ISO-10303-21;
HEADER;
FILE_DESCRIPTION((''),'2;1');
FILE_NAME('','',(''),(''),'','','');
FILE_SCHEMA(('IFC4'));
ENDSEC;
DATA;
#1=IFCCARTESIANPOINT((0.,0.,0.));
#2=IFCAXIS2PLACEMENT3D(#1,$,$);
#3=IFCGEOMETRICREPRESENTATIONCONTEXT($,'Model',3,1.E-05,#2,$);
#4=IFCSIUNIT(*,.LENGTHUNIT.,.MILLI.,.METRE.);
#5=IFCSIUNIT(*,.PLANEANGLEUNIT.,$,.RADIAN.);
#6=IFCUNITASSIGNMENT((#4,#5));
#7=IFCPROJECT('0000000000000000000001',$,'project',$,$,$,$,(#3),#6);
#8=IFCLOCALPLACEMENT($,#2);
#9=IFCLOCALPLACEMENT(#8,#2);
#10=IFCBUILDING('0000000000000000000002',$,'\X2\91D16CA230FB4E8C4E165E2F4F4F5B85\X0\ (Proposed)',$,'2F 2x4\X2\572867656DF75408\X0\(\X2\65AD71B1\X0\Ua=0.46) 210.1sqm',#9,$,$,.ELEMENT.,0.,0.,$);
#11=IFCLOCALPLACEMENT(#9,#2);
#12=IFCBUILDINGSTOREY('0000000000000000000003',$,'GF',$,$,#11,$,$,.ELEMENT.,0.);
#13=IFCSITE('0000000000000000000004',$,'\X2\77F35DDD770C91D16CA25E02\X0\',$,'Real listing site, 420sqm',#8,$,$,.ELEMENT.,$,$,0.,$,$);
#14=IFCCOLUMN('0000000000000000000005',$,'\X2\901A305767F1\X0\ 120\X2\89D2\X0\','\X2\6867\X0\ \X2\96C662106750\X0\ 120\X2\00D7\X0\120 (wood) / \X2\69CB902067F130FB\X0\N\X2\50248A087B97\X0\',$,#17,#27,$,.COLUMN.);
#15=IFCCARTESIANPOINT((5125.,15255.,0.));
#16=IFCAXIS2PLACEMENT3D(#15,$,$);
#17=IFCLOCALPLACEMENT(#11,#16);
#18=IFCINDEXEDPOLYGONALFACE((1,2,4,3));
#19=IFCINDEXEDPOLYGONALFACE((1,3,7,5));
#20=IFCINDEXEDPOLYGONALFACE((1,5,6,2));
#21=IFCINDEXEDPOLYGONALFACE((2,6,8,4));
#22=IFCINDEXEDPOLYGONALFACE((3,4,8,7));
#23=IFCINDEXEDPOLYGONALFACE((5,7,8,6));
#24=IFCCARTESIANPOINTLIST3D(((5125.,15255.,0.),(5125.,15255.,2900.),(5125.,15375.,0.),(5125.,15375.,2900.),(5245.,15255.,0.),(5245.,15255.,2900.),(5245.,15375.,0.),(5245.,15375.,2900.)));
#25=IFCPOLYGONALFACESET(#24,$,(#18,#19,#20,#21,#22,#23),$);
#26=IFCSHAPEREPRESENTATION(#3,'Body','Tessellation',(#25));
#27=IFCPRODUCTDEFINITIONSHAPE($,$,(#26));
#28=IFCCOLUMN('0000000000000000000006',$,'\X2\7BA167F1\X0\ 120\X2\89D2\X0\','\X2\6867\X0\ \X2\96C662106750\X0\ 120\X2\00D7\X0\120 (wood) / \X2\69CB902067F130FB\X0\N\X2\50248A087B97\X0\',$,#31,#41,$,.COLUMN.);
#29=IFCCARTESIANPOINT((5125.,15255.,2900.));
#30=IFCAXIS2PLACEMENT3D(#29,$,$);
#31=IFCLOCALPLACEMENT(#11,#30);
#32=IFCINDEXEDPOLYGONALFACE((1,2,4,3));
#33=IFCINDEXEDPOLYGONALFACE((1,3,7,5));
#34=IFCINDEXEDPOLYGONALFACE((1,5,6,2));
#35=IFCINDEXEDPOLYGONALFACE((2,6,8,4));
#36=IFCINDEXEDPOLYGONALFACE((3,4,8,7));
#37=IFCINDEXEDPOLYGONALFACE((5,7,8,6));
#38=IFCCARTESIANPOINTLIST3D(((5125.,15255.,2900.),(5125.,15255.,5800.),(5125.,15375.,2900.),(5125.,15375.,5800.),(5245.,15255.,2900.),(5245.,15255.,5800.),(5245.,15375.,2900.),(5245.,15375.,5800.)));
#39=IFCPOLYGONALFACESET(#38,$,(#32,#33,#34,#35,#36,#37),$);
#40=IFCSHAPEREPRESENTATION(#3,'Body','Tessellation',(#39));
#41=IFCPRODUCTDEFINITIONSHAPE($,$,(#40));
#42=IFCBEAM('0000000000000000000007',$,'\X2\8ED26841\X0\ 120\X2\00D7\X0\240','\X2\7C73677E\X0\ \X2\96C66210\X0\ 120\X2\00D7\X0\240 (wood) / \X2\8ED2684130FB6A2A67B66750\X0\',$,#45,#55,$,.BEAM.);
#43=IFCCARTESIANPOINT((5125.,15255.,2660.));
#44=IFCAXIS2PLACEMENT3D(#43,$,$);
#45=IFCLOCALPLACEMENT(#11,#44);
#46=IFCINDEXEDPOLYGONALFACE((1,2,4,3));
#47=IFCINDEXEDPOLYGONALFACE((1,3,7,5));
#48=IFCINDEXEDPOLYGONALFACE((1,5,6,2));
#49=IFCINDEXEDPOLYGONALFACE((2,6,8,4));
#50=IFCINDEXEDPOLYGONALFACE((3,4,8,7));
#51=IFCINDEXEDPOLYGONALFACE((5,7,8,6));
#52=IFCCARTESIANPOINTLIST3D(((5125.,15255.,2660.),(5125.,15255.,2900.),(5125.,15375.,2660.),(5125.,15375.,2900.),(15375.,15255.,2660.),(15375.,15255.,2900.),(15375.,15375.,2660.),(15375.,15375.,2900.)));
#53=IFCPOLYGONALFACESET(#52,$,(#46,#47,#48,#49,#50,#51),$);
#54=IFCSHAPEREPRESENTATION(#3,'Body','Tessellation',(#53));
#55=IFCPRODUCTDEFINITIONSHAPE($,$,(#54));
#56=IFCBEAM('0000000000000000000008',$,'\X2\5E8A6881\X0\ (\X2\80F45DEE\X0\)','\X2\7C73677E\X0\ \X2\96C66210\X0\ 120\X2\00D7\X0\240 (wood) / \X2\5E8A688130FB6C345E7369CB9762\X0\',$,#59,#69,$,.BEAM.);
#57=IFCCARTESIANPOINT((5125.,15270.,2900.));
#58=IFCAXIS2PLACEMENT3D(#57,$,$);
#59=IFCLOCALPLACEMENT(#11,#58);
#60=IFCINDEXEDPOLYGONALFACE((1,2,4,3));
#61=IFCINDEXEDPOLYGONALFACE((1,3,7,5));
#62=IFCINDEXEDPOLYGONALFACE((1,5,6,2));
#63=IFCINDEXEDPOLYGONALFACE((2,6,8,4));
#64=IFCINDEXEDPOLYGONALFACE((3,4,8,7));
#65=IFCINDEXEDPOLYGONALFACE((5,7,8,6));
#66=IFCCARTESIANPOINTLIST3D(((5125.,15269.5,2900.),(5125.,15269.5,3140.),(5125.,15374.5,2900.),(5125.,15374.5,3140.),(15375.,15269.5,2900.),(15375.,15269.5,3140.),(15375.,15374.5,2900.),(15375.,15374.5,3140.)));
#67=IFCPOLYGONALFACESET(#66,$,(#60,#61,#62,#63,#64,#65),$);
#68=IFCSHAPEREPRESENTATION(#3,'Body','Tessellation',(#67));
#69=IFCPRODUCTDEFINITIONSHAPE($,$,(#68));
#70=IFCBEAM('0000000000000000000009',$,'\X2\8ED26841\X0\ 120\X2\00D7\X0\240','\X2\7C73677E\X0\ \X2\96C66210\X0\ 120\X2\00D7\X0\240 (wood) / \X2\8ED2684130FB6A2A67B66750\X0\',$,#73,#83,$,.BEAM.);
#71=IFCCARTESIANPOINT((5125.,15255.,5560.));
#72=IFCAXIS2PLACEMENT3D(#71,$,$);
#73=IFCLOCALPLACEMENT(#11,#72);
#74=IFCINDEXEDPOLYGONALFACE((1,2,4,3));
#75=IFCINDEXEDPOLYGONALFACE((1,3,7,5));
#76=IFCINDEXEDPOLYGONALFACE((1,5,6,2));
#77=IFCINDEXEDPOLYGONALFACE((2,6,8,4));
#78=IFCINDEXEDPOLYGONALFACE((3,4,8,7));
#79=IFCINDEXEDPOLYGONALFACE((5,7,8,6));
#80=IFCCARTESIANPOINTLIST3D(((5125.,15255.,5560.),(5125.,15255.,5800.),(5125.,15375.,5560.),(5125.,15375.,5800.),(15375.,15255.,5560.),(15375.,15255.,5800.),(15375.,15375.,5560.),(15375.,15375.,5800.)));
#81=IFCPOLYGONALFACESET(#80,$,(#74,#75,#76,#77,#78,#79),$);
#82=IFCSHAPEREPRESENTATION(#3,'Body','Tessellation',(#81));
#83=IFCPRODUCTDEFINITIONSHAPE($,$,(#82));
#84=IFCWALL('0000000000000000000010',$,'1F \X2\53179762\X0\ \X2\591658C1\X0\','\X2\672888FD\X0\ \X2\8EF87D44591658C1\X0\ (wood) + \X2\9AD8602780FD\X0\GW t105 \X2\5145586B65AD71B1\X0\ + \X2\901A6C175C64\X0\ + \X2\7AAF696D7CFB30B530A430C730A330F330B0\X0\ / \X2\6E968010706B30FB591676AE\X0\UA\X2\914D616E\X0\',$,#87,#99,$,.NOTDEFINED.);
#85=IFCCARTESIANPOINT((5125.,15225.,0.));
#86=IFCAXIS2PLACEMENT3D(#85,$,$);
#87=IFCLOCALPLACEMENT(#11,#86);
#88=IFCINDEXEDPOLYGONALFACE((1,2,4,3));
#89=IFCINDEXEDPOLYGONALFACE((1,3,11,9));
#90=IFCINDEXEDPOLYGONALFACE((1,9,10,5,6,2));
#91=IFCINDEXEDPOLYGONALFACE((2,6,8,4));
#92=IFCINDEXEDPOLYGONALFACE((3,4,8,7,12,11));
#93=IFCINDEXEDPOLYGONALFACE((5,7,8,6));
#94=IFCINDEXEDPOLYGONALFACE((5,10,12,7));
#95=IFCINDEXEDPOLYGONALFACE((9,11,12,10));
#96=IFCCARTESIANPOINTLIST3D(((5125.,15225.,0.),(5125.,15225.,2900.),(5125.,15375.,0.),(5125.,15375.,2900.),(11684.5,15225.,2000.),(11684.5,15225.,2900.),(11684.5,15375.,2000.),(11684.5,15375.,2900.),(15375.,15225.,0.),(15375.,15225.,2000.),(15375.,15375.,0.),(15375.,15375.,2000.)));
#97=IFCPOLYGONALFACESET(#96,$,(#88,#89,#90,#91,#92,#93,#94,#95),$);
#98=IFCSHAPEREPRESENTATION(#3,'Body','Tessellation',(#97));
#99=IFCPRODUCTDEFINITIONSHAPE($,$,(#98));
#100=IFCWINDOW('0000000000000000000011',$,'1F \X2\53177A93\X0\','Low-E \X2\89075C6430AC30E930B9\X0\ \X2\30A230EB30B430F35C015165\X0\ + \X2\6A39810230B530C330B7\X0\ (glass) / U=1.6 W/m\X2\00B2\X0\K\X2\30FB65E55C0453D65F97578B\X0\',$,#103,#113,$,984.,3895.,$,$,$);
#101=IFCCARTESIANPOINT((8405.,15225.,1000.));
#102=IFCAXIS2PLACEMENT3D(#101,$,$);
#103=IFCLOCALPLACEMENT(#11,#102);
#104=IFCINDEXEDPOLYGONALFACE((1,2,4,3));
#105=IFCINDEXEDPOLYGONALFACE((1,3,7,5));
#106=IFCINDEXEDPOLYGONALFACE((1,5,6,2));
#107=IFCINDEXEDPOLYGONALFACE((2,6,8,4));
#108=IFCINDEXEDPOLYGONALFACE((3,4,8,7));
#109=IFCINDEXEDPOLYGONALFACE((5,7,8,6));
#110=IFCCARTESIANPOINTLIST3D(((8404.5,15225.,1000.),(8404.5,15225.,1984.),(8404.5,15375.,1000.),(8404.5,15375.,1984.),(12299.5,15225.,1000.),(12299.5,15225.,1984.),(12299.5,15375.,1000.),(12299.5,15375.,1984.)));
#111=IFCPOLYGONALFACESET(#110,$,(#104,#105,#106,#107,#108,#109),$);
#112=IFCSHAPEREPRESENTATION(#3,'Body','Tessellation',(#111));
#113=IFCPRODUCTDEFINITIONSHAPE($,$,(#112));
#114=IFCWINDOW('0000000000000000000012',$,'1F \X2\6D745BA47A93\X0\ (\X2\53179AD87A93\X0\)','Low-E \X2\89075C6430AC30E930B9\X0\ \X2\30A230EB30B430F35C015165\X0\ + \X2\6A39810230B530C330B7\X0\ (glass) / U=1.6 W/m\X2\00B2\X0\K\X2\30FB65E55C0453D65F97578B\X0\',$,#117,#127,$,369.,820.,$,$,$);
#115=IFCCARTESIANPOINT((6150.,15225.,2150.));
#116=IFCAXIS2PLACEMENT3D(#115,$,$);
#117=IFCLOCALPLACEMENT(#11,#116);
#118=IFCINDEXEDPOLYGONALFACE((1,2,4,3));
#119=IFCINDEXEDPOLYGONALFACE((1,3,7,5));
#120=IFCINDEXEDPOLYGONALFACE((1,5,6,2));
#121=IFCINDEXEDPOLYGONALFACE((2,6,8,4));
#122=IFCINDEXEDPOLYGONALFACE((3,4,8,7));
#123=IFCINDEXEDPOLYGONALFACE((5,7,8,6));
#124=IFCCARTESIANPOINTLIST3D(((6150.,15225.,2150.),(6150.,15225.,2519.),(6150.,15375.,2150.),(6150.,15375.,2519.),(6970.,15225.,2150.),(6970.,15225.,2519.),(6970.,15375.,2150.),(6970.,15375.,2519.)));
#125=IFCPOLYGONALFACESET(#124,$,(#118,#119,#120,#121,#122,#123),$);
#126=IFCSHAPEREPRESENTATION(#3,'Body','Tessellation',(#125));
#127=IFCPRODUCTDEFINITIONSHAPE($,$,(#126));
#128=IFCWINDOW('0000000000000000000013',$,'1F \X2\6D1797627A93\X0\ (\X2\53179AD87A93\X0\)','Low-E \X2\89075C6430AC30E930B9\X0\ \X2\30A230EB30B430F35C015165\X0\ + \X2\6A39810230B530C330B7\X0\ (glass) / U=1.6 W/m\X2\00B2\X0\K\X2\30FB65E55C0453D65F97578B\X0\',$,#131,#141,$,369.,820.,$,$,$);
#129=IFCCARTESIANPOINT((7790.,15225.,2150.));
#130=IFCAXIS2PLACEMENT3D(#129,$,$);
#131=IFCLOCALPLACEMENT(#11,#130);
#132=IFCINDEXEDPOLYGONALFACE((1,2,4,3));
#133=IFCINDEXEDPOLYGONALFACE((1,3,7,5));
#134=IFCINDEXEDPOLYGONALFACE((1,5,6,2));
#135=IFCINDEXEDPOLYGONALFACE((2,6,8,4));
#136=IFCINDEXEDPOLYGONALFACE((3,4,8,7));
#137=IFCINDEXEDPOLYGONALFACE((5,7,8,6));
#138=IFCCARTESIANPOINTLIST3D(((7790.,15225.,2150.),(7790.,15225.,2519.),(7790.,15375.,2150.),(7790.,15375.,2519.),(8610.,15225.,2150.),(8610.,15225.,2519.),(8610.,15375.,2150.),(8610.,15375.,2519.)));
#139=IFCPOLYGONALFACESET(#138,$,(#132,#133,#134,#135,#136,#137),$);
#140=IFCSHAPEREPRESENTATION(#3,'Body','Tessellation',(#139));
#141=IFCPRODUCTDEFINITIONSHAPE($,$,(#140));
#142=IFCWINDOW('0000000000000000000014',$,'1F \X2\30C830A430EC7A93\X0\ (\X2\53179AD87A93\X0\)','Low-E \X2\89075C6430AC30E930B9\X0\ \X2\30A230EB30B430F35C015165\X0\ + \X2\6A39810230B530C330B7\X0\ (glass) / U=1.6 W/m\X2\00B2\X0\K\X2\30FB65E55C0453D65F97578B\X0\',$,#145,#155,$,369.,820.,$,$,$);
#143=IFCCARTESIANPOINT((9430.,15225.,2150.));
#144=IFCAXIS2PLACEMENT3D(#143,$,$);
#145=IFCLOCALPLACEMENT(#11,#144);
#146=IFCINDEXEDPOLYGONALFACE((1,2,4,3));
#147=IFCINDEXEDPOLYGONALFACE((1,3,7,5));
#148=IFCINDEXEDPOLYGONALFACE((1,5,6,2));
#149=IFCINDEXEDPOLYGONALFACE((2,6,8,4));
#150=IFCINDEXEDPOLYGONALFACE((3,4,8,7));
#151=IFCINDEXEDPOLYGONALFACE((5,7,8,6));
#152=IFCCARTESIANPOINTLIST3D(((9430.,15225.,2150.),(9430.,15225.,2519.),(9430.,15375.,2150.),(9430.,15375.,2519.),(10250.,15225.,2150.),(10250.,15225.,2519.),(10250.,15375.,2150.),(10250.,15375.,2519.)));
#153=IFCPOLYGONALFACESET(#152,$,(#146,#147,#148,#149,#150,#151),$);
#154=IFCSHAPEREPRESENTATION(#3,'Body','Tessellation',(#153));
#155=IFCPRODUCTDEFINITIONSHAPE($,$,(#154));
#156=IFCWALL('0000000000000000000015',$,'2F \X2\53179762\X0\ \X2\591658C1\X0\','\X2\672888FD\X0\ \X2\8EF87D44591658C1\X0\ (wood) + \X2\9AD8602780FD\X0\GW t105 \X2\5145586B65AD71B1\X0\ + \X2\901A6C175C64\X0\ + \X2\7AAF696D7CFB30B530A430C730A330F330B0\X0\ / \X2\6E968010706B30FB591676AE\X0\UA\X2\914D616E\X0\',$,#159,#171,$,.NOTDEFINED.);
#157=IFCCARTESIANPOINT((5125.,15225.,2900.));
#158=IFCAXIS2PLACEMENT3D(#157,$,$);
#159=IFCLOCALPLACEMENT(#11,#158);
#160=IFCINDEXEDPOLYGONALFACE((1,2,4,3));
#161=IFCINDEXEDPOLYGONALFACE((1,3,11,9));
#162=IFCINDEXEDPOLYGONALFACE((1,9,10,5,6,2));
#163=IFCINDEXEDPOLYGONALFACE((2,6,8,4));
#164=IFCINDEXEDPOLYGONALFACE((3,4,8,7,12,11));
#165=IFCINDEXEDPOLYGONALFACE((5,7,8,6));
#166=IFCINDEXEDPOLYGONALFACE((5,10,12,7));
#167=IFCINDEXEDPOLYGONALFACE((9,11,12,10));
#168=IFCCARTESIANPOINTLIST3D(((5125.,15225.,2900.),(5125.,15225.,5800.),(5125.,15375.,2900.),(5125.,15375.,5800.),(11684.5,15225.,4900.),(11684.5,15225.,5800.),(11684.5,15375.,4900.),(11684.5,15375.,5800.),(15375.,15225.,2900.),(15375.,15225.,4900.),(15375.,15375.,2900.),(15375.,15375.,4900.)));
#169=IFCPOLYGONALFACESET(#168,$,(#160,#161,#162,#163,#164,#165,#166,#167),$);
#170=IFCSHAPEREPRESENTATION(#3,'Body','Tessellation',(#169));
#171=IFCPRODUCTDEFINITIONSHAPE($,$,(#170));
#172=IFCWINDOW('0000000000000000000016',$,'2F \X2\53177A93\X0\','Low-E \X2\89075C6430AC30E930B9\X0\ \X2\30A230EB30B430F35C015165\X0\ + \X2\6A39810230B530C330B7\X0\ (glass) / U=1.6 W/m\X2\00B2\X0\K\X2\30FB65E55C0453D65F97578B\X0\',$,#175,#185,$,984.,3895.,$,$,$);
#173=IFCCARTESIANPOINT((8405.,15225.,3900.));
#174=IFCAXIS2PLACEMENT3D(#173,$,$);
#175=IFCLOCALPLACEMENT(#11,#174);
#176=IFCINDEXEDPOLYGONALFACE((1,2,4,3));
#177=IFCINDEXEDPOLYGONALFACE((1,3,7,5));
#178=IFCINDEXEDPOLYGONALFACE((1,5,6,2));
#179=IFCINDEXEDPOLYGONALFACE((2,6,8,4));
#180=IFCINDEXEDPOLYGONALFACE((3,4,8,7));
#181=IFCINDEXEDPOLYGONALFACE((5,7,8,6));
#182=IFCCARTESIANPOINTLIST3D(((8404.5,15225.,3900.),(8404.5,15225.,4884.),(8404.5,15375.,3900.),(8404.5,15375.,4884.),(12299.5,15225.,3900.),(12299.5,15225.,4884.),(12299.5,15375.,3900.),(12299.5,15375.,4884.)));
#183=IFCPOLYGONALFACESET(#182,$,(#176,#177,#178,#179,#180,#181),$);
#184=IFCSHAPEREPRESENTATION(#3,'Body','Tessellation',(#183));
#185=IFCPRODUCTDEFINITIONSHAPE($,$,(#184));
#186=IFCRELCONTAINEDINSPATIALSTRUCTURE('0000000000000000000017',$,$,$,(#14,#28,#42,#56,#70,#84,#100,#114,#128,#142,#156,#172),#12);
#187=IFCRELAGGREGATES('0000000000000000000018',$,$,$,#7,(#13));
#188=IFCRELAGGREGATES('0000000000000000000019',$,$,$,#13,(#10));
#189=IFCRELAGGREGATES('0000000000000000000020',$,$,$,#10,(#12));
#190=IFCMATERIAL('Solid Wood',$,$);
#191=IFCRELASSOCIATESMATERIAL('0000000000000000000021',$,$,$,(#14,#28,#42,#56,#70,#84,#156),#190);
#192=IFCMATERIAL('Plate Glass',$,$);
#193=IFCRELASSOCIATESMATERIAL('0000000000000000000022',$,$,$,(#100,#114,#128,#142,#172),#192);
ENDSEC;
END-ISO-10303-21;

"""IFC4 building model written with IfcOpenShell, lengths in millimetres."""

from ifc_helpers import new_model, si_unit, frame, frame_2d, origin, place, context, project, spatial, rectangle, extrude, material, element, fill, save


model = new_model("IFC4")

# Units and contexts
model_context = context("Model", 3, precision=1e-05, world=origin())
ifc_project = project(units=[si_unit("LENGTHUNIT", "METRE", prefix="MILLI"), si_unit("PLANEANGLEUNIT", "RADIAN")], contexts=[model_context])

# Site, building, storey
site_placement = place(None, origin())
site = spatial("IfcSite", under=ifc_project, at=site_placement, Name="石川県金沢市", ObjectType="Real listing site, 420sqm", CompositionType="ELEMENT", RefElevation=0.0)
building_placement = place(site_placement, origin())
building = spatial("IfcBuilding", under=site, at=building_placement, Name="金沢・二世帯住宅 (Proposed)", ObjectType="2F 2x4在来混合(断熱Ua=0.46) 210.1sqm", CompositionType="ELEMENT", ElevationOfRefHeight=0.0, ElevationOfTerrain=0.0)
storey_placement = place(building_placement, origin())
storey = spatial("IfcBuildingStorey", under=building, at=storey_placement, Name="GF", CompositionType="ELEMENT", Elevation=0.0)

# Columns
ifc_material_1 = material(Name="Solid Wood")
column_1_placement = place(storey_placement, frame((5125.0, 15255.0, 0.0)))
element("IfcColumn", 1, at=column_1_placement, inside=storey, material=ifc_material_1, Name="通し柱 120角", Description="桧 集成材 120×120 (wood) / 構造柱・N値計算", PredefinedType="COLUMN", context=model_context, shape_type="SweptSolid", body=[
    extrude(rectangle(XDim=120.0, YDim=120.0, at=frame_2d((60.0, 60.0))), frame((5125.0, 15255.0, 0.0)), (0.0, 0.0, 1.0), 2900.0),
])
column_2_placement = place(storey_placement, frame((5125.0, 15255.0, 2900.0)))
element("IfcColumn", 2, at=column_2_placement, inside=storey, material=ifc_material_1, Name="管柱 120角", Description="桧 集成材 120×120 (wood) / 構造柱・N値計算", PredefinedType="COLUMN", context=model_context, shape_type="SweptSolid", body=[
    extrude(rectangle(XDim=120.0, YDim=120.0, at=frame_2d((60.0, 60.0))), frame((5125.0, 15255.0, 2900.0)), (0.0, 0.0, 1.0), 2900.0),
])

# Beams
beam_1_placement = place(storey_placement, frame((5125.0, 15255.0, 2660.0)))
element("IfcBeam", 3, at=beam_1_placement, inside=storey, material=ifc_material_1, Name="軒桁 120×240", Description="米松 集成 120×240 (wood) / 軒桁・横架材", PredefinedType="BEAM", context=model_context, shape_type="SweptSolid", body=[
    extrude(rectangle(XDim=10250.0, YDim=120.0, at=frame_2d((5125.0, 60.0))), frame((5125.0, 15255.0, 2660.0)), (0.0, 0.0, 1.0), 240.0),
])
beam_2_placement = place(storey_placement, frame((5125.0, 15270.0, 2900.0)))
element("IfcBeam", 4, at=beam_2_placement, inside=storey, material=ifc_material_1, Name="床梁 (胴差)", Description="米松 集成 120×240 (wood) / 床梁・水平構面", PredefinedType="BEAM", context=model_context, shape_type="SweptSolid", body=[
    extrude(rectangle(XDim=10250.0, YDim=105.0, at=frame_2d((5125.0, 52.0))), frame((5125.0, 15270.0, 2900.0)), (0.0, 0.0, 1.0), 240.0),
])
beam_3_placement = place(storey_placement, frame((5125.0, 15255.0, 5560.0)))
element("IfcBeam", 5, at=beam_3_placement, inside=storey, material=ifc_material_1, Name="軒桁 120×240", Description="米松 集成 120×240 (wood) / 軒桁・横架材", PredefinedType="BEAM", context=model_context, shape_type="SweptSolid", body=[
    extrude(rectangle(XDim=10250.0, YDim=120.0, at=frame_2d((5125.0, 60.0))), frame((5125.0, 15255.0, 5560.0)), (0.0, 0.0, 1.0), 240.0),
])

# Wall, openings, windows
wall_1_placement = place(storey_placement, frame((5125.0, 15225.0, 0.0)))
wall_1 = element("IfcWall", 6, at=wall_1_placement, inside=storey, material=ifc_material_1, Name="1F 北面 外壁", Description="木製 軸組外壁 (wood) + 高性能GW t105 充填断熱 + 通気層 + 窯業系サイディング / 準耐火・外皮UA配慮", PredefinedType="NOTDEFINED", context=model_context, shape_type="SweptSolid", body=[
    extrude(rectangle(XDim=10250.0, YDim=150.0, at=frame_2d((5125.0, 75.0))), frame((5125.0, 15225.0, 0.0)), (0.0, 0.0, 1.0), 2900.0),
])
opening_1_placement = place(storey_placement, frame((8405.0, 15225.0, 1000.0)))
opening_1 = element("IfcOpeningElement", 7, at=opening_1_placement, cuts=wall_1, PredefinedType="NOTDEFINED", context=model_context, shape_type="SweptSolid", body=[
    extrude(rectangle(XDim=3895.0, YDim=150.0, at=frame_2d((1947.0, 75.0))), frame((8405.0, 15225.0, 1000.0)), (0.0, 0.0, 1.0), 984.0),
])
opening_2_placement = place(storey_placement, frame((6150.0, 15225.0, 2150.0)))
opening_2 = element("IfcOpeningElement", 8, at=opening_2_placement, cuts=wall_1, PredefinedType="NOTDEFINED", context=model_context, shape_type="SweptSolid", body=[
    extrude(rectangle(XDim=820.0, YDim=150.0, at=frame_2d((410.0, 75.0))), frame((6150.0, 15225.0, 2150.0)), (0.0, 0.0, 1.0), 369.0),
])
opening_3_placement = place(storey_placement, frame((7790.0, 15225.0, 2150.0)))
opening_3 = element("IfcOpeningElement", 9, at=opening_3_placement, cuts=wall_1, PredefinedType="NOTDEFINED", context=model_context, shape_type="SweptSolid", body=[
    extrude(rectangle(XDim=820.0, YDim=150.0, at=frame_2d((410.0, 75.0))), frame((7790.0, 15225.0, 2150.0)), (0.0, 0.0, 1.0), 369.0),
])
opening_4_placement = place(storey_placement, frame((9430.0, 15225.0, 2150.0)))
opening_4 = element("IfcOpeningElement", 10, at=opening_4_placement, cuts=wall_1, PredefinedType="NOTDEFINED", context=model_context, shape_type="SweptSolid", body=[
    extrude(rectangle(XDim=820.0, YDim=150.0, at=frame_2d((410.0, 75.0))), frame((9430.0, 15225.0, 2150.0)), (0.0, 0.0, 1.0), 369.0),
])
ifc_material_2 = material(Name="Plate Glass")
window_1_placement = place(storey_placement, frame((8405.0, 15225.0, 1000.0)))
window_1 = element("IfcWindow", 11, at=window_1_placement, inside=storey, material=ifc_material_2, Name="1F 北窓", Description="Low-E 複層ガラス アルゴン封入 + 樹脂サッシ (glass) / U=1.6 W/m²K・日射取得型", OverallHeight=984.0, OverallWidth=3895.0, context=model_context, shape_type="SweptSolid", body=[
    extrude(rectangle(XDim=3895.0, YDim=150.0, at=frame_2d((1947.0, 75.0))), frame((8405.0, 15225.0, 1000.0)), (0.0, 0.0, 1.0), 984.0),
])
fill(opening_1, window_1)
window_2_placement = place(storey_placement, frame((6150.0, 15225.0, 2150.0)))
window_2 = element("IfcWindow", 12, at=window_2_placement, inside=storey, material=ifc_material_2, Name="1F 浴室窓 (北高窓)", Description="Low-E 複層ガラス アルゴン封入 + 樹脂サッシ (glass) / U=1.6 W/m²K・日射取得型", OverallHeight=369.0, OverallWidth=820.0, context=model_context, shape_type="SweptSolid", body=[
    extrude(rectangle(XDim=820.0, YDim=150.0, at=frame_2d((410.0, 75.0))), frame((6150.0, 15225.0, 2150.0)), (0.0, 0.0, 1.0), 369.0),
])
fill(opening_2, window_2)
window_3_placement = place(storey_placement, frame((7790.0, 15225.0, 2150.0)))
window_3 = element("IfcWindow", 13, at=window_3_placement, inside=storey, material=ifc_material_2, Name="1F 洗面窓 (北高窓)", Description="Low-E 複層ガラス アルゴン封入 + 樹脂サッシ (glass) / U=1.6 W/m²K・日射取得型", OverallHeight=369.0, OverallWidth=820.0, context=model_context, shape_type="SweptSolid", body=[
    extrude(rectangle(XDim=820.0, YDim=150.0, at=frame_2d((410.0, 75.0))), frame((7790.0, 15225.0, 2150.0)), (0.0, 0.0, 1.0), 369.0),
])
fill(opening_3, window_3)
window_4_placement = place(storey_placement, frame((9430.0, 15225.0, 2150.0)))
window_4 = element("IfcWindow", 14, at=window_4_placement, inside=storey, material=ifc_material_2, Name="1F トイレ窓 (北高窓)", Description="Low-E 複層ガラス アルゴン封入 + 樹脂サッシ (glass) / U=1.6 W/m²K・日射取得型", OverallHeight=369.0, OverallWidth=820.0, context=model_context, shape_type="SweptSolid", body=[
    extrude(rectangle(XDim=820.0, YDim=150.0, at=frame_2d((410.0, 75.0))), frame((9430.0, 15225.0, 2150.0)), (0.0, 0.0, 1.0), 369.0),
])
fill(opening_4, window_4)

# Wall, opening, window
wall_2_placement = place(storey_placement, frame((5125.0, 15225.0, 2900.0)))
wall_2 = element("IfcWall", 15, at=wall_2_placement, inside=storey, material=ifc_material_1, Name="2F 北面 外壁", Description="木製 軸組外壁 (wood) + 高性能GW t105 充填断熱 + 通気層 + 窯業系サイディング / 準耐火・外皮UA配慮", PredefinedType="NOTDEFINED", context=model_context, shape_type="SweptSolid", body=[
    extrude(rectangle(XDim=10250.0, YDim=150.0, at=frame_2d((5125.0, 75.0))), frame((5125.0, 15225.0, 2900.0)), (0.0, 0.0, 1.0), 2900.0),
])
opening_5_placement = place(storey_placement, frame((8405.0, 15225.0, 3900.0)))
opening_5 = element("IfcOpeningElement", 16, at=opening_5_placement, cuts=wall_2, PredefinedType="NOTDEFINED", context=model_context, shape_type="SweptSolid", body=[
    extrude(rectangle(XDim=3895.0, YDim=150.0, at=frame_2d((1947.0, 75.0))), frame((8405.0, 15225.0, 3900.0)), (0.0, 0.0, 1.0), 984.0),
])
window_5_placement = place(storey_placement, frame((8405.0, 15225.0, 3900.0)))
window_5 = element("IfcWindow", 17, at=window_5_placement, inside=storey, material=ifc_material_2, Name="2F 北窓", Description="Low-E 複層ガラス アルゴン封入 + 樹脂サッシ (glass) / U=1.6 W/m²K・日射取得型", OverallHeight=984.0, OverallWidth=3895.0, context=model_context, shape_type="SweptSolid", body=[
    extrude(rectangle(XDim=3895.0, YDim=150.0, at=frame_2d((1947.0, 75.0))), frame((8405.0, 15225.0, 3900.0)), (0.0, 0.0, 1.0), 984.0),
])
fill(opening_5, window_5)

save(model, "model.ifc")
